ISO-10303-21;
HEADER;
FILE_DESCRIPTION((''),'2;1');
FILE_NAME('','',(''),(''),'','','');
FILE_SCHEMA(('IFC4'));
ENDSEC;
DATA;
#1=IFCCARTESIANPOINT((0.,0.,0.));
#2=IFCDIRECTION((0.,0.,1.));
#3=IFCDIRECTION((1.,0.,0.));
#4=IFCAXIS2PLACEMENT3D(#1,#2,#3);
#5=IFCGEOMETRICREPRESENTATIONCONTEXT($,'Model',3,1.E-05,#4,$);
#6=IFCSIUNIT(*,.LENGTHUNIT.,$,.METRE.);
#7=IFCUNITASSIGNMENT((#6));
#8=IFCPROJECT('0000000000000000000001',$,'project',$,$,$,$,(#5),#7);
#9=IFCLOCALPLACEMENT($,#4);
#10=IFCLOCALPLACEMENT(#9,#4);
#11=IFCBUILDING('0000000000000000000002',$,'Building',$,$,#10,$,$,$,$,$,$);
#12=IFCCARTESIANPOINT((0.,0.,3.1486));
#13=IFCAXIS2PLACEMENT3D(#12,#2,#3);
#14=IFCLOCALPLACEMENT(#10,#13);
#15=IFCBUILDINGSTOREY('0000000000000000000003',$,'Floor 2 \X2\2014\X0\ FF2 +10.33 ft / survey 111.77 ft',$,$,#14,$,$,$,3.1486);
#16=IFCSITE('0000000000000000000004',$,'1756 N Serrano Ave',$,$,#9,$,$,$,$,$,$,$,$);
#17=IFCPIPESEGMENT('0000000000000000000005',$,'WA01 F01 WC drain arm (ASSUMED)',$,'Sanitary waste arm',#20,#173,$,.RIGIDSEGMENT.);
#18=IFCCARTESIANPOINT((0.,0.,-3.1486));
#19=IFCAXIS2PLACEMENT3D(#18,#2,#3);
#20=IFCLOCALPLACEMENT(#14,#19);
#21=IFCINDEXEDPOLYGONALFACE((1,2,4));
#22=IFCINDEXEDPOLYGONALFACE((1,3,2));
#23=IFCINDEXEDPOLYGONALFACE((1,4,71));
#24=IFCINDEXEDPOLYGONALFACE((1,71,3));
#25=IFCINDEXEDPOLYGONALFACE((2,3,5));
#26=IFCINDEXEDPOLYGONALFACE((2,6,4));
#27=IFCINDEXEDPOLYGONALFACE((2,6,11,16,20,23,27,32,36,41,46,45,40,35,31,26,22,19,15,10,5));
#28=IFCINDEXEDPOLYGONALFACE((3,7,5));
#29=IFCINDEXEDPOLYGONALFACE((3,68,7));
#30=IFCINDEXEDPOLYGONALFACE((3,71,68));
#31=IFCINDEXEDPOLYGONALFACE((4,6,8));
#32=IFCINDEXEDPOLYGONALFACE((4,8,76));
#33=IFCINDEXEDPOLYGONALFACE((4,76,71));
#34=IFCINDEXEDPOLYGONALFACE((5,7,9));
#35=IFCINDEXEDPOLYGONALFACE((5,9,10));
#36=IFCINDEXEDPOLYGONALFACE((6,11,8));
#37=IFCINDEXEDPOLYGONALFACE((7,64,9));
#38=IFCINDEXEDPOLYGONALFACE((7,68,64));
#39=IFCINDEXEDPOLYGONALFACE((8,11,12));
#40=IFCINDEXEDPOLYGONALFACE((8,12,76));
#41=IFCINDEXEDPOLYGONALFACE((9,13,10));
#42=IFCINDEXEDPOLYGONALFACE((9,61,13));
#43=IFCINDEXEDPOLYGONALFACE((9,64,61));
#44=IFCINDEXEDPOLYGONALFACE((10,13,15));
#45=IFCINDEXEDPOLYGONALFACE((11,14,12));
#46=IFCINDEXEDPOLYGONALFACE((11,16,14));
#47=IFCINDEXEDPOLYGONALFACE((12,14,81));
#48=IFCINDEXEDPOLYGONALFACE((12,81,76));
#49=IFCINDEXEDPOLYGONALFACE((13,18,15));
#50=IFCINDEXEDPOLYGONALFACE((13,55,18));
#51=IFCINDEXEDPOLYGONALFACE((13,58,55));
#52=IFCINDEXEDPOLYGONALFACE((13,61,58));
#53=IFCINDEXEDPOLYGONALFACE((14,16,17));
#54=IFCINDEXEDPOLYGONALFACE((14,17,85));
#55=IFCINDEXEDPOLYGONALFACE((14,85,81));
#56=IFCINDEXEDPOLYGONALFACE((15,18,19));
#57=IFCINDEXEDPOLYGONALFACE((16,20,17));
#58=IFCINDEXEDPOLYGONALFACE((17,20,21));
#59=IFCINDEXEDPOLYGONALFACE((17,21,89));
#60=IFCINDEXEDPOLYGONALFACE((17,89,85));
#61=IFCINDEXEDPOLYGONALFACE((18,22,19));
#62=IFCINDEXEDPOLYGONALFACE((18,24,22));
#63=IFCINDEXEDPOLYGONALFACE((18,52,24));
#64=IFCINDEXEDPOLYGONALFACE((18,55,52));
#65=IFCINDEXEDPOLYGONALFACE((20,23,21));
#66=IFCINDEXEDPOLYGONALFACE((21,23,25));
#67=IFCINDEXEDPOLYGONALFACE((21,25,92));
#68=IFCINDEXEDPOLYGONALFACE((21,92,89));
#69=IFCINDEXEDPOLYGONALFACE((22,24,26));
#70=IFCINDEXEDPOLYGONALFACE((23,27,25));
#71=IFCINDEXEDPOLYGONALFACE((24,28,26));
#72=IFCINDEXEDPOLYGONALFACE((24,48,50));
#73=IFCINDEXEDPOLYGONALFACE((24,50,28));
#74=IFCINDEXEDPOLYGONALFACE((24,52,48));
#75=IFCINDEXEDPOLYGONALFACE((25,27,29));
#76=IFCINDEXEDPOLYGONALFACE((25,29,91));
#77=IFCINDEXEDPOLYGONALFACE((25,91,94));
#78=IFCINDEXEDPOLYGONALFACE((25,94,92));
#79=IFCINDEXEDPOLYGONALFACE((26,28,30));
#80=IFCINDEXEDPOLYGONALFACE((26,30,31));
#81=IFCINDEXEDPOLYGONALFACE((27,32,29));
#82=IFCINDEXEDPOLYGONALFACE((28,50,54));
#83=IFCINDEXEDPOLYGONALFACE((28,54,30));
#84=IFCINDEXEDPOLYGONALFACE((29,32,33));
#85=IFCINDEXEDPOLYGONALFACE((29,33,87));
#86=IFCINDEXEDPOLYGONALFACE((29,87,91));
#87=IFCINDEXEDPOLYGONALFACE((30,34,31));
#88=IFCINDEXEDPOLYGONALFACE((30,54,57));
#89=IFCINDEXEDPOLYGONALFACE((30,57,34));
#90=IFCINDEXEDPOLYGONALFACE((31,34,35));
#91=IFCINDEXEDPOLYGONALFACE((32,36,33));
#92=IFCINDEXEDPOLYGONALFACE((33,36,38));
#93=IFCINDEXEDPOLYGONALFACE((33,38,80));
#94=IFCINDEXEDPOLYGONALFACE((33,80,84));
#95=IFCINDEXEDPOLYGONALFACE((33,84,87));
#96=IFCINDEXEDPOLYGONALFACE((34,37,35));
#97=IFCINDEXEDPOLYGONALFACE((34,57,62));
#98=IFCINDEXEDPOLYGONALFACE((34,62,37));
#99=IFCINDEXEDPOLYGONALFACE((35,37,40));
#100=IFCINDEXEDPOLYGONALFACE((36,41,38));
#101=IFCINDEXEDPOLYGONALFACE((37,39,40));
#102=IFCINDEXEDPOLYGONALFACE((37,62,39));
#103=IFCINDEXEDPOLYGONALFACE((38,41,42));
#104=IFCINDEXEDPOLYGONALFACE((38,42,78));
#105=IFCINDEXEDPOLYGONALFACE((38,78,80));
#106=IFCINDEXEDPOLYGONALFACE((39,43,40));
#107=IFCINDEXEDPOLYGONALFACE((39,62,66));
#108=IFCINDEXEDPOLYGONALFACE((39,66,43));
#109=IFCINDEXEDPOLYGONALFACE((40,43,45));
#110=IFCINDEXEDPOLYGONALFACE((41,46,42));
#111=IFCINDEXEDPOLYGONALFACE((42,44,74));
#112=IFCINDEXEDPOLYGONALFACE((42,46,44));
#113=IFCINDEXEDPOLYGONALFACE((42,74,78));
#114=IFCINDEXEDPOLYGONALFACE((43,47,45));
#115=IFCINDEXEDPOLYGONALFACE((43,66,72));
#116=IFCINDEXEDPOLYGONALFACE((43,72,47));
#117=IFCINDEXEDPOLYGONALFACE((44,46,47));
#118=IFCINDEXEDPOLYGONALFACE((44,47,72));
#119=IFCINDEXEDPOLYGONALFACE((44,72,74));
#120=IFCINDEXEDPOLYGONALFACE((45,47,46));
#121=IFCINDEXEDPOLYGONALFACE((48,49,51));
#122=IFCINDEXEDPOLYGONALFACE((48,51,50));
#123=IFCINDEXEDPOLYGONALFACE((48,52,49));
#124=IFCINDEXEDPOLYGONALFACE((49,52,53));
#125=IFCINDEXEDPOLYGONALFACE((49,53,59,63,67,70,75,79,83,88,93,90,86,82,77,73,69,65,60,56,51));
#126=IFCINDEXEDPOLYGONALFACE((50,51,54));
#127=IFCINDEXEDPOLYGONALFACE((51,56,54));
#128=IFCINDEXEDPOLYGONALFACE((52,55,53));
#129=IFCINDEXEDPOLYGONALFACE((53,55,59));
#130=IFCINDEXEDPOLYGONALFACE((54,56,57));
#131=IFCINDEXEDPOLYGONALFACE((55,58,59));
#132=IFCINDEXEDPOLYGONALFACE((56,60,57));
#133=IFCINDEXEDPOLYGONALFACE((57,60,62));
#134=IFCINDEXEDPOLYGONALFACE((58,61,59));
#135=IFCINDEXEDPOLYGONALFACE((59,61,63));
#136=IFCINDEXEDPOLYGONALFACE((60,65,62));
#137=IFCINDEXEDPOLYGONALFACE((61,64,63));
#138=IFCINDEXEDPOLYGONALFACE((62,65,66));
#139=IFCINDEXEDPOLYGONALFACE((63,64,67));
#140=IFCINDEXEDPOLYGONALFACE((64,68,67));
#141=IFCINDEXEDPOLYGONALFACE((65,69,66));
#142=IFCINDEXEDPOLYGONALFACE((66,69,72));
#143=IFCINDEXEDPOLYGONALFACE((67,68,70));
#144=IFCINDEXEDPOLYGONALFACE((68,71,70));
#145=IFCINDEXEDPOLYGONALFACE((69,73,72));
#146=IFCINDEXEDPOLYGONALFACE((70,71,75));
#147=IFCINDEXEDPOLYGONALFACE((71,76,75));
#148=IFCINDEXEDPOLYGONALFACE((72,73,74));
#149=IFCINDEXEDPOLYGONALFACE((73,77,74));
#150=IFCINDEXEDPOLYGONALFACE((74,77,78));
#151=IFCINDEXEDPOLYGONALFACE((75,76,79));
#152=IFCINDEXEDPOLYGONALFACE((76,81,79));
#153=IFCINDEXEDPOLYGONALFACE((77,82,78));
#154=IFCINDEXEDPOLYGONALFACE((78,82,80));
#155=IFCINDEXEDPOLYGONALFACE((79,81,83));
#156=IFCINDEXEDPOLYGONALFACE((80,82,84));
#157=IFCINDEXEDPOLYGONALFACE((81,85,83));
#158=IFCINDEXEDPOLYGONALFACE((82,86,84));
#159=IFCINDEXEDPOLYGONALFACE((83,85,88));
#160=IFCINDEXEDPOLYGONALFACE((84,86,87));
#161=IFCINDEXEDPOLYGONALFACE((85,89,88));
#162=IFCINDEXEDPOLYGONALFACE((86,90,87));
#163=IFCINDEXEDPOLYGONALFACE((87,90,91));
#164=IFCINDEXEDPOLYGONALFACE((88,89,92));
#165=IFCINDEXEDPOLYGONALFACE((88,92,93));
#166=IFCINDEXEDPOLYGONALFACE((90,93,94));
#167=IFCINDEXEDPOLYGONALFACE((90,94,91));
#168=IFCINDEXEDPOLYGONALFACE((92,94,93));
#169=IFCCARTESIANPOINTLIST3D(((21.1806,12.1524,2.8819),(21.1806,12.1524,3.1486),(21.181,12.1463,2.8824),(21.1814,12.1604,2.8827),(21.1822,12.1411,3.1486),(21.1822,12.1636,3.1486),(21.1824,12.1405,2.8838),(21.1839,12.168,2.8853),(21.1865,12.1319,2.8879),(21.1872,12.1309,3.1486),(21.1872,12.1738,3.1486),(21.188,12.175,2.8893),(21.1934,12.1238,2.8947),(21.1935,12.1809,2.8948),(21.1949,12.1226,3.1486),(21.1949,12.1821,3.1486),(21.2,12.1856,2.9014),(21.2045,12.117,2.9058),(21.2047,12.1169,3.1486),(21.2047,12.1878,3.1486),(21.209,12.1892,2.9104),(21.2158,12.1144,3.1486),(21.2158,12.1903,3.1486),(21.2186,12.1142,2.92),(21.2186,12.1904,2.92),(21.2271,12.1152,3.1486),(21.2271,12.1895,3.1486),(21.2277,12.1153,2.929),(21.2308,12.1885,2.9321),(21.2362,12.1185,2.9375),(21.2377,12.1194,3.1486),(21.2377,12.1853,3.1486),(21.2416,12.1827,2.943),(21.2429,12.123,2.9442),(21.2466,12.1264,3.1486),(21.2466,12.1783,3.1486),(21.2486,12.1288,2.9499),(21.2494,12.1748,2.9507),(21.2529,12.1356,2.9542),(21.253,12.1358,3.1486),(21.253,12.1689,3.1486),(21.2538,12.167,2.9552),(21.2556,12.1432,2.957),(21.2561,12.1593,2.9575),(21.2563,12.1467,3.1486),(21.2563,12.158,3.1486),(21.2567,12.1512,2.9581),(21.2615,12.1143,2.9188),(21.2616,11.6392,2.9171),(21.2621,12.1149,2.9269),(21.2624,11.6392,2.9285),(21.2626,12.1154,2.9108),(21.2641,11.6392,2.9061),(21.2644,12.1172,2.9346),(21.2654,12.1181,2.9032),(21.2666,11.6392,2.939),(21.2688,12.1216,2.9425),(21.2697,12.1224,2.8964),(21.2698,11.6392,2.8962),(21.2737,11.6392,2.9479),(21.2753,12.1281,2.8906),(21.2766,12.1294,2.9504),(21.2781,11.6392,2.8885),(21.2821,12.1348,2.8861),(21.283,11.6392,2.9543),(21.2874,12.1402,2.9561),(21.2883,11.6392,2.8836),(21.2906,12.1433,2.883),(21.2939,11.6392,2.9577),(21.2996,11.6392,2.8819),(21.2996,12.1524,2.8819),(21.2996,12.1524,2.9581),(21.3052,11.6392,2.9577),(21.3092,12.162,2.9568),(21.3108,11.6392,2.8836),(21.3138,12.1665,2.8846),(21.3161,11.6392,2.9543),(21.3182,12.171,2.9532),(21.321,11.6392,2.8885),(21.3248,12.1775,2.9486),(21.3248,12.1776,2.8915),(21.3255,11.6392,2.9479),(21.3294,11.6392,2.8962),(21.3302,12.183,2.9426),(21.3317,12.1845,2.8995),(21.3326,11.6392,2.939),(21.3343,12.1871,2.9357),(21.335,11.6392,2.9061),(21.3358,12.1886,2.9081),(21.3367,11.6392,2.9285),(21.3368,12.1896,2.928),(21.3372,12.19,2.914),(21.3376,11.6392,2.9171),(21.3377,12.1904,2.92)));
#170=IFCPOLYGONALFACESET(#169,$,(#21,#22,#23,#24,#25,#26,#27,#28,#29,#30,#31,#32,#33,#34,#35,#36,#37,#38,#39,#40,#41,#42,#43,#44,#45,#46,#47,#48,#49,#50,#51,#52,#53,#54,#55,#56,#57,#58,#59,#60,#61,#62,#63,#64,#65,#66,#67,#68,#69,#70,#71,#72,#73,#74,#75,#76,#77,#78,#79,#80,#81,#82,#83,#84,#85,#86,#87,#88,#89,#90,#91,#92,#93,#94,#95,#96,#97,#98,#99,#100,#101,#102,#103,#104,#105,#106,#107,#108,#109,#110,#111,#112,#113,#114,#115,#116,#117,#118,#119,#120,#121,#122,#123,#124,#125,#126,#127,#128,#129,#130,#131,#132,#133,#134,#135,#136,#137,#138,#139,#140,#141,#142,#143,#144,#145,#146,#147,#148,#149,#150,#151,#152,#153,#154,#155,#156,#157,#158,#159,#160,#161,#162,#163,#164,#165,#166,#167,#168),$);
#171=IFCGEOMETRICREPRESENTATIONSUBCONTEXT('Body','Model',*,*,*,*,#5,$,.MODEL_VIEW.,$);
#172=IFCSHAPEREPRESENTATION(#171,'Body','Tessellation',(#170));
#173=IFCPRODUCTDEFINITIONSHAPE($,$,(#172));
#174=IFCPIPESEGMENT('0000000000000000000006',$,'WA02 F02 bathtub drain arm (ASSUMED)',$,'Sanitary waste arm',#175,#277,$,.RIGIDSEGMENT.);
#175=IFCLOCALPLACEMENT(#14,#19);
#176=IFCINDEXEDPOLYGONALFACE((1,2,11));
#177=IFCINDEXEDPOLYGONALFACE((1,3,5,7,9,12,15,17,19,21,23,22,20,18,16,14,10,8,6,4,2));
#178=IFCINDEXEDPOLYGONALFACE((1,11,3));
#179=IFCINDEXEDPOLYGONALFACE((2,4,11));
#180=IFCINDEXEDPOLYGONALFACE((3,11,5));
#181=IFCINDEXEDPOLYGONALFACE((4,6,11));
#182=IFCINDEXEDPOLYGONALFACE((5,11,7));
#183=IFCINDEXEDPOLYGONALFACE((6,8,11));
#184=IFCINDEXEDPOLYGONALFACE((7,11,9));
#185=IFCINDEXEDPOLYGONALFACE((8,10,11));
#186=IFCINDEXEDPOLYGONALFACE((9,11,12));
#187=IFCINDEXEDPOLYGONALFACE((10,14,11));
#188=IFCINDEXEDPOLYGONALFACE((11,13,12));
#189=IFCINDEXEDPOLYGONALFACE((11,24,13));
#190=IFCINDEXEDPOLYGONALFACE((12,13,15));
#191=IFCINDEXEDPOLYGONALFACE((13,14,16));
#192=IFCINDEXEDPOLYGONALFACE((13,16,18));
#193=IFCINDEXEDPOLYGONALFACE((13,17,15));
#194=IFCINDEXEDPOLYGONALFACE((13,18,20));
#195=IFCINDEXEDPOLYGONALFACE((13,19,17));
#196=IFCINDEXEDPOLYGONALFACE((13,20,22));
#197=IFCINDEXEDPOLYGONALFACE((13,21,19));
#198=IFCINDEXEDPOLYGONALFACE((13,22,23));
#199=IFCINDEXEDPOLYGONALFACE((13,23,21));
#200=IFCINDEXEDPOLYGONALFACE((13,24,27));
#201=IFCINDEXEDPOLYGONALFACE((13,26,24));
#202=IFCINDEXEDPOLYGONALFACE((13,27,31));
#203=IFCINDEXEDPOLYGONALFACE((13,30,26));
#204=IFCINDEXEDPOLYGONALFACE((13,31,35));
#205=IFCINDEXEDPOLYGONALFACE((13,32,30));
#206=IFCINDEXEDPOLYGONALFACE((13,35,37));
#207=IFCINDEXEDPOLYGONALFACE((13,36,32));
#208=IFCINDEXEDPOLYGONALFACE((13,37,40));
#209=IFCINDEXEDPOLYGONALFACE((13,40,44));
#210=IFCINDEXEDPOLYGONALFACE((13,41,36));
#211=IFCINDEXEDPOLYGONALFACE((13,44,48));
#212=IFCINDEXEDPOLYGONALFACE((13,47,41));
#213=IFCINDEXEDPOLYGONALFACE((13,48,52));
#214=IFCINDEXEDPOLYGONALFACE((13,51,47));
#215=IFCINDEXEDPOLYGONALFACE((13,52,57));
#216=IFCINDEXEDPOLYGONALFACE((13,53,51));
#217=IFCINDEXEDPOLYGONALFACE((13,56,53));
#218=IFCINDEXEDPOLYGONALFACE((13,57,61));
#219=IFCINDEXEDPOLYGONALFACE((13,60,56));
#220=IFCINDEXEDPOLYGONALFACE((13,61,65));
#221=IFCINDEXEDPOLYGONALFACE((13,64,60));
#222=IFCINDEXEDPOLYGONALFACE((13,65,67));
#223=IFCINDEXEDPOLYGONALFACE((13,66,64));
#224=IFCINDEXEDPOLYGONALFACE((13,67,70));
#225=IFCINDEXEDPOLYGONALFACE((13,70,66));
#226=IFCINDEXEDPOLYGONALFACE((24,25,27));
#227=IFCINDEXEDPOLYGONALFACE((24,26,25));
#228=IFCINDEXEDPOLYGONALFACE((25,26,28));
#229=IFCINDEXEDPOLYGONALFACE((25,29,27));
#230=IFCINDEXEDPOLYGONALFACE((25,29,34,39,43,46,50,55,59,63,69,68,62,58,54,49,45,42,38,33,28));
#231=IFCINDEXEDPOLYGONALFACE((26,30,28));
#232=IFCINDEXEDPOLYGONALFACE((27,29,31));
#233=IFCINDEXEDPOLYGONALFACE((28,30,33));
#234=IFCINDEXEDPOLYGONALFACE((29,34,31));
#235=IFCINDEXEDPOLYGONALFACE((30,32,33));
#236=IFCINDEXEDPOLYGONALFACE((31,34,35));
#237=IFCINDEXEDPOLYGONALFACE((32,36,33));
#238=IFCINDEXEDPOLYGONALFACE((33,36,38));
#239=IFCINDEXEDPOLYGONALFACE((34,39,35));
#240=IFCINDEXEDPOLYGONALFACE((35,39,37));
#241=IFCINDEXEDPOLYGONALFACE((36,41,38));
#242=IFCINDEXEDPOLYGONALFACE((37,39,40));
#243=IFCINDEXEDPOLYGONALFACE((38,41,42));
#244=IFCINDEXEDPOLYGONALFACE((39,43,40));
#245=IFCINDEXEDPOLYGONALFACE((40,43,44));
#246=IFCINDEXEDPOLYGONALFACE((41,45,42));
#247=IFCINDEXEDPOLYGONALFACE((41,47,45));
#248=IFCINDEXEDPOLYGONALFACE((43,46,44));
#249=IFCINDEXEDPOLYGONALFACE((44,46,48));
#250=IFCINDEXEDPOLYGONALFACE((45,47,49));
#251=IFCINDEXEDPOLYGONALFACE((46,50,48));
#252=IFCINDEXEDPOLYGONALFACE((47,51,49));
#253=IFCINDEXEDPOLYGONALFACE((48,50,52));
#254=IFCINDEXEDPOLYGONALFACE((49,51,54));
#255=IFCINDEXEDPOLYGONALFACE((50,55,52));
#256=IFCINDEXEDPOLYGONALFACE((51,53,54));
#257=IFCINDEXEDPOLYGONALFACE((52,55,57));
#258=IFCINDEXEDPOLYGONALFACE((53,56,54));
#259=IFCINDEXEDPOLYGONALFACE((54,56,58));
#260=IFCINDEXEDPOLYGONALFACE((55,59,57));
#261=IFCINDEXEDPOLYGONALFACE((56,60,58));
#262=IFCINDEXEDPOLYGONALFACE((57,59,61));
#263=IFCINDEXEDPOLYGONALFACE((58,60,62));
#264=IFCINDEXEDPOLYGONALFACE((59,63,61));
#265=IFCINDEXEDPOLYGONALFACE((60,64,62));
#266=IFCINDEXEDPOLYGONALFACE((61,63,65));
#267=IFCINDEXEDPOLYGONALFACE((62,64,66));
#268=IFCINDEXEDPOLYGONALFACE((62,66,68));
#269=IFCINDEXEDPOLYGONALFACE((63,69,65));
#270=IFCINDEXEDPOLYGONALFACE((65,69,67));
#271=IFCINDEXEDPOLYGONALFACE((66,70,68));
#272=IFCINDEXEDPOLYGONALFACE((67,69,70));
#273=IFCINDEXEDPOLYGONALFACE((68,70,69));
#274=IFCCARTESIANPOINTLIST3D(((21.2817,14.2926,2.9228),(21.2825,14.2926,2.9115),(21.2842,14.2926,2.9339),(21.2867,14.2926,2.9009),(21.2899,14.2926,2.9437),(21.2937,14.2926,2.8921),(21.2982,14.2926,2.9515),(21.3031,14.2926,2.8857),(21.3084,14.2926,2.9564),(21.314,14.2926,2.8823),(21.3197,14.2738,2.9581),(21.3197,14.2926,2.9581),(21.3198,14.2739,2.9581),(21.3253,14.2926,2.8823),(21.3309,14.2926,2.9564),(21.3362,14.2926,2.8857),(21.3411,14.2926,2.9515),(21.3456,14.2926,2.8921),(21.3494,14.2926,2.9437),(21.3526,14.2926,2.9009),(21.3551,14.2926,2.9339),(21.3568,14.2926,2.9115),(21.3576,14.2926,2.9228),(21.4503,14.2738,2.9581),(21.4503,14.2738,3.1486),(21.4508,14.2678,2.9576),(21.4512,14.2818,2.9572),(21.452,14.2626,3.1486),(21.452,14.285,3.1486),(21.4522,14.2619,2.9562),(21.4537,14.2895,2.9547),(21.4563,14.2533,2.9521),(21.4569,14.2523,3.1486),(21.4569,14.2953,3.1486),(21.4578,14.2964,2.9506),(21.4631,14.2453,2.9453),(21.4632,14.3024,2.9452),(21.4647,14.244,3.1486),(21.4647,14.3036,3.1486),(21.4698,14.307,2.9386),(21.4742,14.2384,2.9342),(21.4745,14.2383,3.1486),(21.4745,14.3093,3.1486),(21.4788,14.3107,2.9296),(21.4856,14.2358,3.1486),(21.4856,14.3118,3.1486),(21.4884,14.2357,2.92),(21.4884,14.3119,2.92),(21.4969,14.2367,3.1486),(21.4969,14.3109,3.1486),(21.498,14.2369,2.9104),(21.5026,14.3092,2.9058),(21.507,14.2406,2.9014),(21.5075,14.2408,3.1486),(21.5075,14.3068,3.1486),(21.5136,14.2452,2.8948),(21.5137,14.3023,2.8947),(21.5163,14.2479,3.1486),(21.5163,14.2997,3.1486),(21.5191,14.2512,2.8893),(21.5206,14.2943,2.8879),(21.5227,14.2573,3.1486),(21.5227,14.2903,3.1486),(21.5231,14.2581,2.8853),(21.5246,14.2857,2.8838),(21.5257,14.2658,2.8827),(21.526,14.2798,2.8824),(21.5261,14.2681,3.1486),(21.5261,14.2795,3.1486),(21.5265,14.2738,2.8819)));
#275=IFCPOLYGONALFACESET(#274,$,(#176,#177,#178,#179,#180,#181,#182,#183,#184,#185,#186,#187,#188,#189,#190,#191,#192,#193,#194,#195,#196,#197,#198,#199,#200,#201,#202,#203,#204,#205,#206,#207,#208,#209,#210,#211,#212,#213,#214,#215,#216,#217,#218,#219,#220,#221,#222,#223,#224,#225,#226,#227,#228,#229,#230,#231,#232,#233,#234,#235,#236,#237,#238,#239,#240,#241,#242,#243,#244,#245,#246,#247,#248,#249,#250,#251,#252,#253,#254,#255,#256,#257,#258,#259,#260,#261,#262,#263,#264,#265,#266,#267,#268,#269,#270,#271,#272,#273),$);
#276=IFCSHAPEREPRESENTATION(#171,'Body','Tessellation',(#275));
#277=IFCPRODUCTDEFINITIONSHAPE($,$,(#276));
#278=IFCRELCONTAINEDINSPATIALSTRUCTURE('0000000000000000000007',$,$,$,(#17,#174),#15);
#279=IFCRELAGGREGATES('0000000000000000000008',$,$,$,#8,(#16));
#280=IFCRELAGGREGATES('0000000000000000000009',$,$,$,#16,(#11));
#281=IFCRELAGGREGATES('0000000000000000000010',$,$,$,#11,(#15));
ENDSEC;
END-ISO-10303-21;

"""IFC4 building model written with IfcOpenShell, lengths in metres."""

from ifc_helpers import new_model, entity, si_unit, frame, origin_with_axes, place, context, subcontext, project, spatial, element, save


model = new_model("IFC4")

# Units and contexts
model_context = context("Model", 3, precision=1e-05, world=origin_with_axes())
body_context = subcontext(model_context, "Body", "Model", "MODEL_VIEW")
ifc_project = project(units=[si_unit("LENGTHUNIT", "METRE")], contexts=[model_context])

# Site, building, storey
site_placement = place(None, origin_with_axes())
site = spatial("IfcSite", under=ifc_project, at=site_placement, Name="1756 N Serrano Ave")
building_placement = place(site_placement, origin_with_axes())
building = spatial("IfcBuilding", under=site, at=building_placement, Name="Building")
storey_placement = place(building_placement, frame((0.0, 0.0, 3.1486), z_axis=(0.0, 0.0, 1.0), x_axis=(1.0, 0.0, 0.0)))
storey = spatial("IfcBuildingStorey", under=building, at=storey_placement, Name="Floor 2 — FF2 +10.33 ft / survey 111.77 ft", Elevation=3.1486)

# Pipe segments
pipe_segment_1_placement = place(storey_placement, frame((0.0, 0.0, -3.1486), z_axis=(0.0, 0.0, 1.0), x_axis=(1.0, 0.0, 0.0)))
element("IfcPipeSegment", 1, at=pipe_segment_1_placement, inside=storey, Name="WA01 F01 WC drain arm (ASSUMED)", ObjectType="Sanitary waste arm", PredefinedType="RIGIDSEGMENT", context=body_context, shape_type="AdvancedSweptSolid", body=[
    entity("IfcSweptDiskSolid", entity("IfcPolyline", [entity("IfcCartesianPoint", [21.2187, 12.1524, 3.1486]), entity("IfcCartesianPoint", [21.2187, 12.1524, 2.92]), entity("IfcCartesianPoint", [21.2996, 12.1524, 2.92]), entity("IfcCartesianPoint", [21.2996, 11.6392, 2.92])]), 0.0381),
])
pipe_segment_2_placement = place(storey_placement, frame((0.0, 0.0, -3.1486), z_axis=(0.0, 0.0, 1.0), x_axis=(1.0, 0.0, 0.0)))
element("IfcPipeSegment", 2, at=pipe_segment_2_placement, inside=storey, Name="WA02 F02 bathtub drain arm (ASSUMED)", ObjectType="Sanitary waste arm", PredefinedType="RIGIDSEGMENT", context=body_context, shape_type="AdvancedSweptSolid", body=[
    entity("IfcSweptDiskSolid", entity("IfcPolyline", [entity("IfcCartesianPoint", [21.4884, 14.2738, 3.1486]), entity("IfcCartesianPoint", [21.4884, 14.2738, 2.92]), entity("IfcCartesianPoint", [21.3197, 14.2738, 2.92]), entity("IfcCartesianPoint", [21.3197, 14.2926, 2.92])]), 0.0381),
])

save(model, "model.ifc")
